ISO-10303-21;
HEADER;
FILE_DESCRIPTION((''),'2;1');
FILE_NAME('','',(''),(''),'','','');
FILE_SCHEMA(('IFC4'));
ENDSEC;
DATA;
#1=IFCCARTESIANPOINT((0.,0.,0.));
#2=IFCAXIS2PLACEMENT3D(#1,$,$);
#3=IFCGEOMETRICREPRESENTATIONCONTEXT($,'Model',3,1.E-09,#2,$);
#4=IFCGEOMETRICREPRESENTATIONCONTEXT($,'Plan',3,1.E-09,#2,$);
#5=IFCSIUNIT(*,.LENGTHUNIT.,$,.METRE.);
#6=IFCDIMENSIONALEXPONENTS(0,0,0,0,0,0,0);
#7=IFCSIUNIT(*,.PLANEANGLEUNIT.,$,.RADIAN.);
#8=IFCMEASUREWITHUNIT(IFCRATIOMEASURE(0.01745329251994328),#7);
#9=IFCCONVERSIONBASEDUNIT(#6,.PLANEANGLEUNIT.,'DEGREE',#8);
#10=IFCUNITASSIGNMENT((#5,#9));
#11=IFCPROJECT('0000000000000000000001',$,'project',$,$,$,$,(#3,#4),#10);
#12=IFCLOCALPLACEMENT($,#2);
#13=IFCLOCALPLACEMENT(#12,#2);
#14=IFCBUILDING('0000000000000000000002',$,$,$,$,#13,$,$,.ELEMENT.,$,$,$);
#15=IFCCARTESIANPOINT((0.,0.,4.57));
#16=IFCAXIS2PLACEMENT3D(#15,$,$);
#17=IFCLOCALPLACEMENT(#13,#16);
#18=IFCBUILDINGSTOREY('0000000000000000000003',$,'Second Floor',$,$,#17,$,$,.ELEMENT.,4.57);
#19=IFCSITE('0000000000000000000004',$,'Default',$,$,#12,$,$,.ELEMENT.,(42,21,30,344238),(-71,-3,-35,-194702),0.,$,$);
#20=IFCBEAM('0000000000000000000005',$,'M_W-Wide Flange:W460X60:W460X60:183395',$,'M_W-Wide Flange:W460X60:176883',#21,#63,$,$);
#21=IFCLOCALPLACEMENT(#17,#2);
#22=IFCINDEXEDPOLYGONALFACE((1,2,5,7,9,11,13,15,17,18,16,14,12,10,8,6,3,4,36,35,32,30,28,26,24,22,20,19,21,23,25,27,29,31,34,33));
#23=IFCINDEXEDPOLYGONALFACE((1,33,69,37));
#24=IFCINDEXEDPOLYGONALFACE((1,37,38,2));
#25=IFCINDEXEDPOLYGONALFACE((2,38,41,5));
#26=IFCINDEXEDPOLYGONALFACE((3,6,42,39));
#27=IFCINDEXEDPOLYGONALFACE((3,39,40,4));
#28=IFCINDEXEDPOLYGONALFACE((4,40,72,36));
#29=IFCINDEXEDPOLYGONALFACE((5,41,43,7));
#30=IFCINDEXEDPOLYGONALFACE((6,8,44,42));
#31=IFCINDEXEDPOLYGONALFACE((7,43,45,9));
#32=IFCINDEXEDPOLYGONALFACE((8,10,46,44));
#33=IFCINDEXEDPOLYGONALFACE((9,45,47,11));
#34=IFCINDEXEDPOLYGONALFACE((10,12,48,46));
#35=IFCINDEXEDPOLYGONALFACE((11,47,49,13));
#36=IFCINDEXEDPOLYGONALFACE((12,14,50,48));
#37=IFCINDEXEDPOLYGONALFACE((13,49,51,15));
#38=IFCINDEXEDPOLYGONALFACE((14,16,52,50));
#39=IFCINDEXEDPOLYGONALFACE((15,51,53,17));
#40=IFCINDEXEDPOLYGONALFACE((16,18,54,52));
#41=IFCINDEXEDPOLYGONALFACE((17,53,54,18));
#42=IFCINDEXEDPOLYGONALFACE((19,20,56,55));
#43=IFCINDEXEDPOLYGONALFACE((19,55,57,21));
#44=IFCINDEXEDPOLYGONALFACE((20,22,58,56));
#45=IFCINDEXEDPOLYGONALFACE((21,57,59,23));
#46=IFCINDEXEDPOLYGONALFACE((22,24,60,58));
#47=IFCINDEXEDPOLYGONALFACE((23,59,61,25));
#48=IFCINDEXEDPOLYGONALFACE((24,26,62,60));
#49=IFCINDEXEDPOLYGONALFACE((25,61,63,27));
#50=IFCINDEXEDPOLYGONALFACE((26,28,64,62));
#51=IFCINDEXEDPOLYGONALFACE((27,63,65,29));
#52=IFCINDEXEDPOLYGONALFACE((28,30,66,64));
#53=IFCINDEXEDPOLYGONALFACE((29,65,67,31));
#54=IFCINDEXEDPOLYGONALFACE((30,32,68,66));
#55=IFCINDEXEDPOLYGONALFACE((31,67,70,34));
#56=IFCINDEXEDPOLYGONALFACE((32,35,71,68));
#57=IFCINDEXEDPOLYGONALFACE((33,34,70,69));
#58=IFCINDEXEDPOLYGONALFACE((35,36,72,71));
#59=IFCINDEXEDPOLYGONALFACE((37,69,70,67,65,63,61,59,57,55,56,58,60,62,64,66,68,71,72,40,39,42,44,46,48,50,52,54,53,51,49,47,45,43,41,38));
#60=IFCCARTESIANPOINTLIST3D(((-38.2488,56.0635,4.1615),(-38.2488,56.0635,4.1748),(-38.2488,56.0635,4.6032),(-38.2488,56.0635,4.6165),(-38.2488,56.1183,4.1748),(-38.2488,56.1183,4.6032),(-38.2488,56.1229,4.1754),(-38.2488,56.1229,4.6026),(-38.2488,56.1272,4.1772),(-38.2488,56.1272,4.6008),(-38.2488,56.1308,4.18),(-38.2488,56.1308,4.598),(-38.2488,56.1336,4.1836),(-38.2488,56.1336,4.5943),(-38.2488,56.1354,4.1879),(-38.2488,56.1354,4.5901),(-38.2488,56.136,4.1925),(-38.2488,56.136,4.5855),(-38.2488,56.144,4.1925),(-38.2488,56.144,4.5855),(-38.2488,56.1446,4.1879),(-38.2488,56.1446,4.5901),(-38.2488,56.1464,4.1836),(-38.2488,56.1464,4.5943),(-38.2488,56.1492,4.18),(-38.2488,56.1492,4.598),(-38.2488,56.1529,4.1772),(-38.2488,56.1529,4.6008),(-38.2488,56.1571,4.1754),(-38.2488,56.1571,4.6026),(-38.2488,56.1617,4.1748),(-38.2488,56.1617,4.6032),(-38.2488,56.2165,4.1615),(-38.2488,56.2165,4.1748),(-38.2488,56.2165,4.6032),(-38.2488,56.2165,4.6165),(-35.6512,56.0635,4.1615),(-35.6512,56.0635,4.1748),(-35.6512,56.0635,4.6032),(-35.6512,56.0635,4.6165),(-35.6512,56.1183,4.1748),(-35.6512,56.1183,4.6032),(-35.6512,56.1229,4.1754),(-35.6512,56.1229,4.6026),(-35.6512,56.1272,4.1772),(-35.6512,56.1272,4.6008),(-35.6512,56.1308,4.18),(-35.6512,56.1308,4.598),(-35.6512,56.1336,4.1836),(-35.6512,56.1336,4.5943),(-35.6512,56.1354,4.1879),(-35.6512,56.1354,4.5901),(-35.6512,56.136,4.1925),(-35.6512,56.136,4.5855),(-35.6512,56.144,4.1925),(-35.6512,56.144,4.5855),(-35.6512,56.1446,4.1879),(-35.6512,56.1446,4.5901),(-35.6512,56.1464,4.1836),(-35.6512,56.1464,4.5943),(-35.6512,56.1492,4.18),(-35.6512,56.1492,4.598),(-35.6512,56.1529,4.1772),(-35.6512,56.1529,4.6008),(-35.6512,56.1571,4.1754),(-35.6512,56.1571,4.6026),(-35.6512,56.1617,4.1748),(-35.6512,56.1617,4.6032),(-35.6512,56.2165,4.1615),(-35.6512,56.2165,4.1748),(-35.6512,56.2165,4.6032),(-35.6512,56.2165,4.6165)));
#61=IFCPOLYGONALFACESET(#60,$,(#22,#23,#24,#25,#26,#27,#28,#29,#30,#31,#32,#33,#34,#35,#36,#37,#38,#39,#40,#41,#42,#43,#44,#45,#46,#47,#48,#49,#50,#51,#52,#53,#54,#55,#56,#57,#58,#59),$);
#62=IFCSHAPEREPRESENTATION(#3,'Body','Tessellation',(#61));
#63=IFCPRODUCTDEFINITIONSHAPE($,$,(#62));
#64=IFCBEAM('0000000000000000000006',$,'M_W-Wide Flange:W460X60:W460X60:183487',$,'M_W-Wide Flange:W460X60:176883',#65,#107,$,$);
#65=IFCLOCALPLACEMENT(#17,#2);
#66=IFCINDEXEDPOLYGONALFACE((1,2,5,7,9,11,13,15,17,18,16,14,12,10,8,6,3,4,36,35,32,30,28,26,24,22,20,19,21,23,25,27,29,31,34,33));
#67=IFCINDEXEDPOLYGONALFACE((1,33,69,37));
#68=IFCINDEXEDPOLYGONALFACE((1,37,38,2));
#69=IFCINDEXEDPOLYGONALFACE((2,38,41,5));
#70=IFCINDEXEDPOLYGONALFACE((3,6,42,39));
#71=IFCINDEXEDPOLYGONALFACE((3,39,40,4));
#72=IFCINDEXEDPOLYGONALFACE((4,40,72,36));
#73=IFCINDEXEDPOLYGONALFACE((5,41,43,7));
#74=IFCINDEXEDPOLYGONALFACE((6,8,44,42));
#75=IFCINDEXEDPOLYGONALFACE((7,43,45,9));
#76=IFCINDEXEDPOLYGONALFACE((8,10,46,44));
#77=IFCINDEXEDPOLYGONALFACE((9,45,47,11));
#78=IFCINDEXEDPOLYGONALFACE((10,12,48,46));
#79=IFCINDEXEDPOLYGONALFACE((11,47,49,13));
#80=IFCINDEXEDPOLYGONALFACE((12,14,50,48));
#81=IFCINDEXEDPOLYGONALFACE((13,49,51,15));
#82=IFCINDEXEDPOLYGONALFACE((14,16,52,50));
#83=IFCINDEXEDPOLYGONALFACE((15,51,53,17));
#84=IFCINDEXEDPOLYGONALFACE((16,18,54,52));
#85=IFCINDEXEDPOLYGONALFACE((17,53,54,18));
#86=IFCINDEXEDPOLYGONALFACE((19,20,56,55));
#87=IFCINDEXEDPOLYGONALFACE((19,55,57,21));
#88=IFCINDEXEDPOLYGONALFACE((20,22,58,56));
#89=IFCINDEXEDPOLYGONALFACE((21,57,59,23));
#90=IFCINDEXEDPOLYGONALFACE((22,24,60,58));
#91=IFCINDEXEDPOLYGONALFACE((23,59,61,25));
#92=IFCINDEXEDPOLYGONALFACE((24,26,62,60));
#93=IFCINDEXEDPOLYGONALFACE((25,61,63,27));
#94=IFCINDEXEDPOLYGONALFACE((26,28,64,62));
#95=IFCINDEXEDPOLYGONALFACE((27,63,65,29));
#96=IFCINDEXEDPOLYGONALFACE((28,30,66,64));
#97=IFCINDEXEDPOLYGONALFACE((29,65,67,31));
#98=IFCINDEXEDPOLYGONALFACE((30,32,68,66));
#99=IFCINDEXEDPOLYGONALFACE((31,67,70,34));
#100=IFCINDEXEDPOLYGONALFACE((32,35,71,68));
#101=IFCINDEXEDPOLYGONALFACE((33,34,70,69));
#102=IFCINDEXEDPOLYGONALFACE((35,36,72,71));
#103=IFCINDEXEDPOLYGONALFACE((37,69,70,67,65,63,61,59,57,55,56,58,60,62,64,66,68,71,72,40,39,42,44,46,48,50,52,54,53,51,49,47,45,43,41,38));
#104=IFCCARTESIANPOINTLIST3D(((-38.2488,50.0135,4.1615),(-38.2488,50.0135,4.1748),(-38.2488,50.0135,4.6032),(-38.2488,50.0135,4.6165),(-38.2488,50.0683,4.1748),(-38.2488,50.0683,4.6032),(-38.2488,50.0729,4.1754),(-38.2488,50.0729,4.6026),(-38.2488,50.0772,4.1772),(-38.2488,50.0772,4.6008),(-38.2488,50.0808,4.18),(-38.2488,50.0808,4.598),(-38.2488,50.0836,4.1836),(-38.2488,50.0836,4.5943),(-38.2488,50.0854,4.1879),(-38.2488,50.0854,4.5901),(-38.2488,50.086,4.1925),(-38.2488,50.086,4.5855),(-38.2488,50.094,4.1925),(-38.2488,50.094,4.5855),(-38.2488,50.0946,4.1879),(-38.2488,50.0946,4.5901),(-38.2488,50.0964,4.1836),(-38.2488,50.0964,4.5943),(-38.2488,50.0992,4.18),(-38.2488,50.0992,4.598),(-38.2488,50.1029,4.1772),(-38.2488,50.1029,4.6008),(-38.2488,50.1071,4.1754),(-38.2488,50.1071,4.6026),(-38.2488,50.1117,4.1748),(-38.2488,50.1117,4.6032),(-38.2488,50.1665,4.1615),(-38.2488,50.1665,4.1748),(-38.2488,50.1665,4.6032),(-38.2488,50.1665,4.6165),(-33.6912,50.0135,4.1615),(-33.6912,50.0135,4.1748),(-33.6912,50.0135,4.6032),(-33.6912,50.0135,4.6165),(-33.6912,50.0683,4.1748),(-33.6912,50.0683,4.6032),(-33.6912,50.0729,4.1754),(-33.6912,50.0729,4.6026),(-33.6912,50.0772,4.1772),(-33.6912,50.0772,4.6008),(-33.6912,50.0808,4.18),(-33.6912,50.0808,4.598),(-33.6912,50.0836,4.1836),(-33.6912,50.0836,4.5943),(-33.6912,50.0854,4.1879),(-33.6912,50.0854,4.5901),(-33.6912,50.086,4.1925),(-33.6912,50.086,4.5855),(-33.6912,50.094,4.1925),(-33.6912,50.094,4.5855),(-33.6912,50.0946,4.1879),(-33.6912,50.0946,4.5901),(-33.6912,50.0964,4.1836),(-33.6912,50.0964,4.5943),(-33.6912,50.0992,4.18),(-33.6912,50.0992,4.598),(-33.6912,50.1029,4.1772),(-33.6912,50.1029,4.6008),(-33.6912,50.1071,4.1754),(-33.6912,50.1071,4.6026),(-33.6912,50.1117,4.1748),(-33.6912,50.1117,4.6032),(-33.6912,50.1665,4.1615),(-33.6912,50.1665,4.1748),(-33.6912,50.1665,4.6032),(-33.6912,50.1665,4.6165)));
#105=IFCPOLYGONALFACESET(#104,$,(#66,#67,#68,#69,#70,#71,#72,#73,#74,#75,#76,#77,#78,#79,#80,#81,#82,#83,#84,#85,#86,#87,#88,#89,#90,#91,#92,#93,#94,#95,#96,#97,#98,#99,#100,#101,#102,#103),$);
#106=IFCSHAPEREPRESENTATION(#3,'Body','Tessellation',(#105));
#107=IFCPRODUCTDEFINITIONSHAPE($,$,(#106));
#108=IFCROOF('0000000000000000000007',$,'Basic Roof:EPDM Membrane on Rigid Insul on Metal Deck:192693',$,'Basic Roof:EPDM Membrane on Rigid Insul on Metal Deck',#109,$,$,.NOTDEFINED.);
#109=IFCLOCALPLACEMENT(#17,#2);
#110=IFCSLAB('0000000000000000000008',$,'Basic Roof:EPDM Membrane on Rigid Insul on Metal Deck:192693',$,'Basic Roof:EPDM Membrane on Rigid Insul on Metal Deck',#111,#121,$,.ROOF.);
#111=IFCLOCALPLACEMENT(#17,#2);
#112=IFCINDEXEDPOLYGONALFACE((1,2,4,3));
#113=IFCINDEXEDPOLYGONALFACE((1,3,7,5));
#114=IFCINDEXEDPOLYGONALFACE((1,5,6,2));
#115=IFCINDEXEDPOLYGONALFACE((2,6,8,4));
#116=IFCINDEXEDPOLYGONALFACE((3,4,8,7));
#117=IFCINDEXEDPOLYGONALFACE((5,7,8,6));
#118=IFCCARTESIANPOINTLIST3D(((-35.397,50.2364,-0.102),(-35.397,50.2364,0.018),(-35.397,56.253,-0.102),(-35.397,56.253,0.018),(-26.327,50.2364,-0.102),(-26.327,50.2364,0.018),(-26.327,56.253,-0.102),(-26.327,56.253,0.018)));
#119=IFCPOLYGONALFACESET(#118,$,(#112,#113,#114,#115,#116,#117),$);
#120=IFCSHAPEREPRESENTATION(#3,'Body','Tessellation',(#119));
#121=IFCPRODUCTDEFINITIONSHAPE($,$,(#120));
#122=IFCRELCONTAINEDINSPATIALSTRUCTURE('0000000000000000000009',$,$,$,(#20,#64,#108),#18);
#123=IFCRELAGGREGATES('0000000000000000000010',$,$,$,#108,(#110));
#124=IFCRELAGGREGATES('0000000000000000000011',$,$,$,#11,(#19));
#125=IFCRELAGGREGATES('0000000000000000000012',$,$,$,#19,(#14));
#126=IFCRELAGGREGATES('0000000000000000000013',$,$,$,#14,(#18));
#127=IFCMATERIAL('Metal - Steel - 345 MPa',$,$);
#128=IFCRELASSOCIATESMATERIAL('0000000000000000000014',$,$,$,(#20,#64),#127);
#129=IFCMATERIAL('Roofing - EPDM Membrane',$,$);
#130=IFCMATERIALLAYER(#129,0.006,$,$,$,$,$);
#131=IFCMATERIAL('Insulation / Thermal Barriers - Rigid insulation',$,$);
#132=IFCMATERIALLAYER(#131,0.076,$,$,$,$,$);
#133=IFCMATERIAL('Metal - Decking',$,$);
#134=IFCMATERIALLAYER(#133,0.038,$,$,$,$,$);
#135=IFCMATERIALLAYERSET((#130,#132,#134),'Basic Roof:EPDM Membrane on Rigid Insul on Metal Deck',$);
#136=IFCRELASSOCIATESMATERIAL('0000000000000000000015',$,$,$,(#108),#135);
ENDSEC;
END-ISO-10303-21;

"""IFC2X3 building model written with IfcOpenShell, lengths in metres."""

from ifc_helpers import new_model, entity, si_unit, converted_unit, frame, frame_2d, origin, origin_2d_with_axis, place, context, project, spatial, polyline, circle_curve, parameter, trimmed, segment, composite_curve, rectangle, outline, extrude, material, layer, layer_set, layer_usage, element, aggregate, save


model = new_model("IFC2X3")

# Units and contexts
model_context = context("Model", 3, precision=1e-09, world=origin())
plan_context = context("Plan", 3, precision=1e-09, world=origin())
ifc_project = project(units=[si_unit("LENGTHUNIT", "METRE"), converted_unit("PLANEANGLEUNIT", "DEGREE", entity("IfcRatioMeasure", 0.01745329251994328), si_unit("PLANEANGLEUNIT", "RADIAN"), dimensions=[0, 0, 0, 0, 0, 0, 0])], contexts=[model_context, plan_context])

# Site, building, storey
site_placement = place(None, origin())
site = spatial("IfcSite", under=ifc_project, at=site_placement, Name="Default", CompositionType="ELEMENT", RefLatitude=(42, 21, 30, 344238), RefLongitude=(-71, -3, -35, -194702), RefElevation=0.0)
building_placement = place(site_placement, origin())
building = spatial("IfcBuilding", under=site, at=building_placement, CompositionType="ELEMENT")
storey_placement = place(building_placement, frame((0.0, 0.0, 4.57)))
storey = spatial("IfcBuildingStorey", under=building, at=storey_placement, Name="Second Floor", CompositionType="ELEMENT", Elevation=4.57)

# Shared definitions
ifc_material_1 = material(Name="Metal - Steel - 345 MPa")

# Beams
beam_1_placement = place(storey_placement, frame((-38.3834, 56.14, 4.6165), z_axis=(0.0, 0.0, 1.0), x_axis=(0.0, -1.0, 0.0)))
element("IfcBeam", 1, at=beam_1_placement, inside=storey, material=ifc_material_1, Name="M_W-Wide Flange:W460X60:W460X60:183395", ObjectType="M_W-Wide Flange:W460X60:176883", context=model_context, shape_type="SweptSolid", body=[
    extrude(outline(composite_curve([segment(polyline([(-0.0765, -0.2142), (-0.0765, -0.2275)]), True, "CONTINUOUS"), segment(polyline([(-0.0765, -0.2275), (0.0765, -0.2275)]), True, "CONTINUOUS"), segment(polyline([(0.0765, -0.2275), (0.0765, -0.2142)]), True, "CONTINUOUS"), segment(polyline([(0.0765, -0.2142), (0.0217, -0.2142)]), True, "CONTINUOUS"), segment(trimmed(circle_curve(frame_2d((0.0217, -0.1965), x_axis=(0.0, -1.0)), 0.0177), [parameter(270.0)], [parameter(360.0)], True, "PARAMETER"), False, "CONTINUOUS"), segment(polyline([(0.004, -0.1965), (0.004, 0.1965)]), True, "CONTINUOUS"), segment(trimmed(circle_curve(frame_2d((0.0217, 0.1965), x_axis=(-1.0, 0.0)), 0.0177), [parameter(270.0)], [parameter(360.0)], True, "PARAMETER"), False, "CONTINUOUS"), segment(polyline([(0.0217, 0.2142), (0.0765, 0.2142)]), True, "CONTINUOUS"), segment(polyline([(0.0765, 0.2142), (0.0765, 0.2275)]), True, "CONTINUOUS"), segment(polyline([(0.0765, 0.2275), (-0.0765, 0.2275)]), True, "CONTINUOUS"), segment(polyline([(-0.0765, 0.2275), (-0.0765, 0.2142)]), True, "CONTINUOUS"), segment(polyline([(-0.0765, 0.2142), (-0.0217, 0.2142)]), True, "CONTINUOUS"), segment(trimmed(circle_curve(frame_2d((-0.0217, 0.1965), x_axis=(0.0, 1.0)), 0.0177), [parameter(270.0)], [parameter(360.0)], True, "PARAMETER"), False, "CONTINUOUS"), segment(polyline([(-0.004, 0.1965), (-0.004, -0.1965)]), True, "CONTINUOUS"), segment(trimmed(circle_curve(frame_2d((-0.0217, -0.1965), x_axis=(1.0, 0.0)), 0.0177), [parameter(270.0)], [parameter(0.0)], True, "PARAMETER"), False, "CONTINUOUS"), segment(polyline([(-0.0217, -0.2142), (-0.0765, -0.2142)]), True, "CONTINUOUS")], self_intersect=False)), frame((0.0, 0.1346, -0.2275), z_axis=(0.0, -1.0, 0.0), x_axis=(1.0, 0.0, 0.0)), (0.0, 0.0, -1.0), 2.5976),
])
beam_2_placement = place(storey_placement, frame((-38.3861, 50.09, 4.6165), z_axis=(0.0, 0.0, 1.0), x_axis=(0.0, -1.0, 0.0)))
element("IfcBeam", 2, at=beam_2_placement, inside=storey, material=ifc_material_1, Name="M_W-Wide Flange:W460X60:W460X60:183487", ObjectType="M_W-Wide Flange:W460X60:176883", context=model_context, shape_type="SweptSolid", body=[
    extrude(outline(composite_curve([segment(polyline([(-0.0765, -0.2142), (-0.0765, -0.2275)]), True, "CONTINUOUS"), segment(polyline([(-0.0765, -0.2275), (0.0765, -0.2275)]), True, "CONTINUOUS"), segment(polyline([(0.0765, -0.2275), (0.0765, -0.2142)]), True, "CONTINUOUS"), segment(polyline([(0.0765, -0.2142), (0.0217, -0.2142)]), True, "CONTINUOUS"), segment(trimmed(circle_curve(frame_2d((0.0217, -0.1965), x_axis=(0.0, -1.0)), 0.0177), [parameter(270.0)], [parameter(360.0)], True, "PARAMETER"), False, "CONTINUOUS"), segment(polyline([(0.004, -0.1965), (0.004, 0.1965)]), True, "CONTINUOUS"), segment(trimmed(circle_curve(frame_2d((0.0217, 0.1965), x_axis=(-1.0, 0.0)), 0.0177), [parameter(270.0)], [parameter(360.0)], True, "PARAMETER"), False, "CONTINUOUS"), segment(polyline([(0.0217, 0.2142), (0.0765, 0.2142)]), True, "CONTINUOUS"), segment(polyline([(0.0765, 0.2142), (0.0765, 0.2275)]), True, "CONTINUOUS"), segment(polyline([(0.0765, 0.2275), (-0.0765, 0.2275)]), True, "CONTINUOUS"), segment(polyline([(-0.0765, 0.2275), (-0.0765, 0.2142)]), True, "CONTINUOUS"), segment(polyline([(-0.0765, 0.2142), (-0.0217, 0.2142)]), True, "CONTINUOUS"), segment(trimmed(circle_curve(frame_2d((-0.0217, 0.1965), x_axis=(0.0, 1.0)), 0.0177), [parameter(270.0)], [parameter(360.0)], True, "PARAMETER"), False, "CONTINUOUS"), segment(polyline([(-0.004, 0.1965), (-0.004, -0.1965)]), True, "CONTINUOUS"), segment(trimmed(circle_curve(frame_2d((-0.0217, -0.1965), x_axis=(1.0, 0.0)), 0.0177), [parameter(270.0)], [parameter(0.0)], True, "PARAMETER"), False, "CONTINUOUS"), segment(polyline([(-0.0217, -0.2142), (-0.0765, -0.2142)]), True, "CONTINUOUS")], self_intersect=False)), frame((0.0, 0.1373, -0.2275), z_axis=(0.0, -1.0, 0.0), x_axis=(1.0, 0.0, 0.0)), (0.0, 0.0, -1.0), 4.5576),
])

# Roof, slab
ifc_material_2 = material(Name="Roofing - EPDM Membrane")
ifc_layer_1 = layer(ifc_material_2, 0.006)
ifc_material_3 = material(Name="Insulation / Thermal Barriers - Rigid insulation")
ifc_layer_2 = layer(ifc_material_3, 0.076)
ifc_material_4 = material(Name="Metal - Decking")
ifc_layer_3 = layer(ifc_material_4, 0.038)
ifc_layer_set = layer_set([ifc_layer_1, ifc_layer_2, ifc_layer_3], Name="Basic Roof:EPDM Membrane on Rigid Insul on Metal Deck")
ifc_layer_usage = layer_usage(ifc_layer_set, "AXIS3", "NEGATIVE", 0.0)
roof_placement = place(storey_placement, origin())
roof = element("IfcRoof", 3, at=roof_placement, inside=storey, material=ifc_layer_usage, Name="Basic Roof:EPDM Membrane on Rigid Insul on Metal Deck:192693", ObjectType="Basic Roof:EPDM Membrane on Rigid Insul on Metal Deck", ShapeType="NOTDEFINED")
slab_placement = place(roof_placement, frame((-35.397, 50.2364, -0.102)))
slab = element("IfcSlab", 4, at=slab_placement, Name="Basic Roof:EPDM Membrane on Rigid Insul on Metal Deck:192693", ObjectType="Basic Roof:EPDM Membrane on Rigid Insul on Metal Deck", PredefinedType="ROOF", context=model_context, shape_type="SweptSolid", body=[
    extrude(rectangle(XDim=9.07, YDim=6.0166, at=origin_2d_with_axis()), frame((4.535, 3.0083, 0.0)), (0.0, 0.0, 1.0), 0.12),
])
aggregate(roof, [slab])

save(model, "model.ifc")
